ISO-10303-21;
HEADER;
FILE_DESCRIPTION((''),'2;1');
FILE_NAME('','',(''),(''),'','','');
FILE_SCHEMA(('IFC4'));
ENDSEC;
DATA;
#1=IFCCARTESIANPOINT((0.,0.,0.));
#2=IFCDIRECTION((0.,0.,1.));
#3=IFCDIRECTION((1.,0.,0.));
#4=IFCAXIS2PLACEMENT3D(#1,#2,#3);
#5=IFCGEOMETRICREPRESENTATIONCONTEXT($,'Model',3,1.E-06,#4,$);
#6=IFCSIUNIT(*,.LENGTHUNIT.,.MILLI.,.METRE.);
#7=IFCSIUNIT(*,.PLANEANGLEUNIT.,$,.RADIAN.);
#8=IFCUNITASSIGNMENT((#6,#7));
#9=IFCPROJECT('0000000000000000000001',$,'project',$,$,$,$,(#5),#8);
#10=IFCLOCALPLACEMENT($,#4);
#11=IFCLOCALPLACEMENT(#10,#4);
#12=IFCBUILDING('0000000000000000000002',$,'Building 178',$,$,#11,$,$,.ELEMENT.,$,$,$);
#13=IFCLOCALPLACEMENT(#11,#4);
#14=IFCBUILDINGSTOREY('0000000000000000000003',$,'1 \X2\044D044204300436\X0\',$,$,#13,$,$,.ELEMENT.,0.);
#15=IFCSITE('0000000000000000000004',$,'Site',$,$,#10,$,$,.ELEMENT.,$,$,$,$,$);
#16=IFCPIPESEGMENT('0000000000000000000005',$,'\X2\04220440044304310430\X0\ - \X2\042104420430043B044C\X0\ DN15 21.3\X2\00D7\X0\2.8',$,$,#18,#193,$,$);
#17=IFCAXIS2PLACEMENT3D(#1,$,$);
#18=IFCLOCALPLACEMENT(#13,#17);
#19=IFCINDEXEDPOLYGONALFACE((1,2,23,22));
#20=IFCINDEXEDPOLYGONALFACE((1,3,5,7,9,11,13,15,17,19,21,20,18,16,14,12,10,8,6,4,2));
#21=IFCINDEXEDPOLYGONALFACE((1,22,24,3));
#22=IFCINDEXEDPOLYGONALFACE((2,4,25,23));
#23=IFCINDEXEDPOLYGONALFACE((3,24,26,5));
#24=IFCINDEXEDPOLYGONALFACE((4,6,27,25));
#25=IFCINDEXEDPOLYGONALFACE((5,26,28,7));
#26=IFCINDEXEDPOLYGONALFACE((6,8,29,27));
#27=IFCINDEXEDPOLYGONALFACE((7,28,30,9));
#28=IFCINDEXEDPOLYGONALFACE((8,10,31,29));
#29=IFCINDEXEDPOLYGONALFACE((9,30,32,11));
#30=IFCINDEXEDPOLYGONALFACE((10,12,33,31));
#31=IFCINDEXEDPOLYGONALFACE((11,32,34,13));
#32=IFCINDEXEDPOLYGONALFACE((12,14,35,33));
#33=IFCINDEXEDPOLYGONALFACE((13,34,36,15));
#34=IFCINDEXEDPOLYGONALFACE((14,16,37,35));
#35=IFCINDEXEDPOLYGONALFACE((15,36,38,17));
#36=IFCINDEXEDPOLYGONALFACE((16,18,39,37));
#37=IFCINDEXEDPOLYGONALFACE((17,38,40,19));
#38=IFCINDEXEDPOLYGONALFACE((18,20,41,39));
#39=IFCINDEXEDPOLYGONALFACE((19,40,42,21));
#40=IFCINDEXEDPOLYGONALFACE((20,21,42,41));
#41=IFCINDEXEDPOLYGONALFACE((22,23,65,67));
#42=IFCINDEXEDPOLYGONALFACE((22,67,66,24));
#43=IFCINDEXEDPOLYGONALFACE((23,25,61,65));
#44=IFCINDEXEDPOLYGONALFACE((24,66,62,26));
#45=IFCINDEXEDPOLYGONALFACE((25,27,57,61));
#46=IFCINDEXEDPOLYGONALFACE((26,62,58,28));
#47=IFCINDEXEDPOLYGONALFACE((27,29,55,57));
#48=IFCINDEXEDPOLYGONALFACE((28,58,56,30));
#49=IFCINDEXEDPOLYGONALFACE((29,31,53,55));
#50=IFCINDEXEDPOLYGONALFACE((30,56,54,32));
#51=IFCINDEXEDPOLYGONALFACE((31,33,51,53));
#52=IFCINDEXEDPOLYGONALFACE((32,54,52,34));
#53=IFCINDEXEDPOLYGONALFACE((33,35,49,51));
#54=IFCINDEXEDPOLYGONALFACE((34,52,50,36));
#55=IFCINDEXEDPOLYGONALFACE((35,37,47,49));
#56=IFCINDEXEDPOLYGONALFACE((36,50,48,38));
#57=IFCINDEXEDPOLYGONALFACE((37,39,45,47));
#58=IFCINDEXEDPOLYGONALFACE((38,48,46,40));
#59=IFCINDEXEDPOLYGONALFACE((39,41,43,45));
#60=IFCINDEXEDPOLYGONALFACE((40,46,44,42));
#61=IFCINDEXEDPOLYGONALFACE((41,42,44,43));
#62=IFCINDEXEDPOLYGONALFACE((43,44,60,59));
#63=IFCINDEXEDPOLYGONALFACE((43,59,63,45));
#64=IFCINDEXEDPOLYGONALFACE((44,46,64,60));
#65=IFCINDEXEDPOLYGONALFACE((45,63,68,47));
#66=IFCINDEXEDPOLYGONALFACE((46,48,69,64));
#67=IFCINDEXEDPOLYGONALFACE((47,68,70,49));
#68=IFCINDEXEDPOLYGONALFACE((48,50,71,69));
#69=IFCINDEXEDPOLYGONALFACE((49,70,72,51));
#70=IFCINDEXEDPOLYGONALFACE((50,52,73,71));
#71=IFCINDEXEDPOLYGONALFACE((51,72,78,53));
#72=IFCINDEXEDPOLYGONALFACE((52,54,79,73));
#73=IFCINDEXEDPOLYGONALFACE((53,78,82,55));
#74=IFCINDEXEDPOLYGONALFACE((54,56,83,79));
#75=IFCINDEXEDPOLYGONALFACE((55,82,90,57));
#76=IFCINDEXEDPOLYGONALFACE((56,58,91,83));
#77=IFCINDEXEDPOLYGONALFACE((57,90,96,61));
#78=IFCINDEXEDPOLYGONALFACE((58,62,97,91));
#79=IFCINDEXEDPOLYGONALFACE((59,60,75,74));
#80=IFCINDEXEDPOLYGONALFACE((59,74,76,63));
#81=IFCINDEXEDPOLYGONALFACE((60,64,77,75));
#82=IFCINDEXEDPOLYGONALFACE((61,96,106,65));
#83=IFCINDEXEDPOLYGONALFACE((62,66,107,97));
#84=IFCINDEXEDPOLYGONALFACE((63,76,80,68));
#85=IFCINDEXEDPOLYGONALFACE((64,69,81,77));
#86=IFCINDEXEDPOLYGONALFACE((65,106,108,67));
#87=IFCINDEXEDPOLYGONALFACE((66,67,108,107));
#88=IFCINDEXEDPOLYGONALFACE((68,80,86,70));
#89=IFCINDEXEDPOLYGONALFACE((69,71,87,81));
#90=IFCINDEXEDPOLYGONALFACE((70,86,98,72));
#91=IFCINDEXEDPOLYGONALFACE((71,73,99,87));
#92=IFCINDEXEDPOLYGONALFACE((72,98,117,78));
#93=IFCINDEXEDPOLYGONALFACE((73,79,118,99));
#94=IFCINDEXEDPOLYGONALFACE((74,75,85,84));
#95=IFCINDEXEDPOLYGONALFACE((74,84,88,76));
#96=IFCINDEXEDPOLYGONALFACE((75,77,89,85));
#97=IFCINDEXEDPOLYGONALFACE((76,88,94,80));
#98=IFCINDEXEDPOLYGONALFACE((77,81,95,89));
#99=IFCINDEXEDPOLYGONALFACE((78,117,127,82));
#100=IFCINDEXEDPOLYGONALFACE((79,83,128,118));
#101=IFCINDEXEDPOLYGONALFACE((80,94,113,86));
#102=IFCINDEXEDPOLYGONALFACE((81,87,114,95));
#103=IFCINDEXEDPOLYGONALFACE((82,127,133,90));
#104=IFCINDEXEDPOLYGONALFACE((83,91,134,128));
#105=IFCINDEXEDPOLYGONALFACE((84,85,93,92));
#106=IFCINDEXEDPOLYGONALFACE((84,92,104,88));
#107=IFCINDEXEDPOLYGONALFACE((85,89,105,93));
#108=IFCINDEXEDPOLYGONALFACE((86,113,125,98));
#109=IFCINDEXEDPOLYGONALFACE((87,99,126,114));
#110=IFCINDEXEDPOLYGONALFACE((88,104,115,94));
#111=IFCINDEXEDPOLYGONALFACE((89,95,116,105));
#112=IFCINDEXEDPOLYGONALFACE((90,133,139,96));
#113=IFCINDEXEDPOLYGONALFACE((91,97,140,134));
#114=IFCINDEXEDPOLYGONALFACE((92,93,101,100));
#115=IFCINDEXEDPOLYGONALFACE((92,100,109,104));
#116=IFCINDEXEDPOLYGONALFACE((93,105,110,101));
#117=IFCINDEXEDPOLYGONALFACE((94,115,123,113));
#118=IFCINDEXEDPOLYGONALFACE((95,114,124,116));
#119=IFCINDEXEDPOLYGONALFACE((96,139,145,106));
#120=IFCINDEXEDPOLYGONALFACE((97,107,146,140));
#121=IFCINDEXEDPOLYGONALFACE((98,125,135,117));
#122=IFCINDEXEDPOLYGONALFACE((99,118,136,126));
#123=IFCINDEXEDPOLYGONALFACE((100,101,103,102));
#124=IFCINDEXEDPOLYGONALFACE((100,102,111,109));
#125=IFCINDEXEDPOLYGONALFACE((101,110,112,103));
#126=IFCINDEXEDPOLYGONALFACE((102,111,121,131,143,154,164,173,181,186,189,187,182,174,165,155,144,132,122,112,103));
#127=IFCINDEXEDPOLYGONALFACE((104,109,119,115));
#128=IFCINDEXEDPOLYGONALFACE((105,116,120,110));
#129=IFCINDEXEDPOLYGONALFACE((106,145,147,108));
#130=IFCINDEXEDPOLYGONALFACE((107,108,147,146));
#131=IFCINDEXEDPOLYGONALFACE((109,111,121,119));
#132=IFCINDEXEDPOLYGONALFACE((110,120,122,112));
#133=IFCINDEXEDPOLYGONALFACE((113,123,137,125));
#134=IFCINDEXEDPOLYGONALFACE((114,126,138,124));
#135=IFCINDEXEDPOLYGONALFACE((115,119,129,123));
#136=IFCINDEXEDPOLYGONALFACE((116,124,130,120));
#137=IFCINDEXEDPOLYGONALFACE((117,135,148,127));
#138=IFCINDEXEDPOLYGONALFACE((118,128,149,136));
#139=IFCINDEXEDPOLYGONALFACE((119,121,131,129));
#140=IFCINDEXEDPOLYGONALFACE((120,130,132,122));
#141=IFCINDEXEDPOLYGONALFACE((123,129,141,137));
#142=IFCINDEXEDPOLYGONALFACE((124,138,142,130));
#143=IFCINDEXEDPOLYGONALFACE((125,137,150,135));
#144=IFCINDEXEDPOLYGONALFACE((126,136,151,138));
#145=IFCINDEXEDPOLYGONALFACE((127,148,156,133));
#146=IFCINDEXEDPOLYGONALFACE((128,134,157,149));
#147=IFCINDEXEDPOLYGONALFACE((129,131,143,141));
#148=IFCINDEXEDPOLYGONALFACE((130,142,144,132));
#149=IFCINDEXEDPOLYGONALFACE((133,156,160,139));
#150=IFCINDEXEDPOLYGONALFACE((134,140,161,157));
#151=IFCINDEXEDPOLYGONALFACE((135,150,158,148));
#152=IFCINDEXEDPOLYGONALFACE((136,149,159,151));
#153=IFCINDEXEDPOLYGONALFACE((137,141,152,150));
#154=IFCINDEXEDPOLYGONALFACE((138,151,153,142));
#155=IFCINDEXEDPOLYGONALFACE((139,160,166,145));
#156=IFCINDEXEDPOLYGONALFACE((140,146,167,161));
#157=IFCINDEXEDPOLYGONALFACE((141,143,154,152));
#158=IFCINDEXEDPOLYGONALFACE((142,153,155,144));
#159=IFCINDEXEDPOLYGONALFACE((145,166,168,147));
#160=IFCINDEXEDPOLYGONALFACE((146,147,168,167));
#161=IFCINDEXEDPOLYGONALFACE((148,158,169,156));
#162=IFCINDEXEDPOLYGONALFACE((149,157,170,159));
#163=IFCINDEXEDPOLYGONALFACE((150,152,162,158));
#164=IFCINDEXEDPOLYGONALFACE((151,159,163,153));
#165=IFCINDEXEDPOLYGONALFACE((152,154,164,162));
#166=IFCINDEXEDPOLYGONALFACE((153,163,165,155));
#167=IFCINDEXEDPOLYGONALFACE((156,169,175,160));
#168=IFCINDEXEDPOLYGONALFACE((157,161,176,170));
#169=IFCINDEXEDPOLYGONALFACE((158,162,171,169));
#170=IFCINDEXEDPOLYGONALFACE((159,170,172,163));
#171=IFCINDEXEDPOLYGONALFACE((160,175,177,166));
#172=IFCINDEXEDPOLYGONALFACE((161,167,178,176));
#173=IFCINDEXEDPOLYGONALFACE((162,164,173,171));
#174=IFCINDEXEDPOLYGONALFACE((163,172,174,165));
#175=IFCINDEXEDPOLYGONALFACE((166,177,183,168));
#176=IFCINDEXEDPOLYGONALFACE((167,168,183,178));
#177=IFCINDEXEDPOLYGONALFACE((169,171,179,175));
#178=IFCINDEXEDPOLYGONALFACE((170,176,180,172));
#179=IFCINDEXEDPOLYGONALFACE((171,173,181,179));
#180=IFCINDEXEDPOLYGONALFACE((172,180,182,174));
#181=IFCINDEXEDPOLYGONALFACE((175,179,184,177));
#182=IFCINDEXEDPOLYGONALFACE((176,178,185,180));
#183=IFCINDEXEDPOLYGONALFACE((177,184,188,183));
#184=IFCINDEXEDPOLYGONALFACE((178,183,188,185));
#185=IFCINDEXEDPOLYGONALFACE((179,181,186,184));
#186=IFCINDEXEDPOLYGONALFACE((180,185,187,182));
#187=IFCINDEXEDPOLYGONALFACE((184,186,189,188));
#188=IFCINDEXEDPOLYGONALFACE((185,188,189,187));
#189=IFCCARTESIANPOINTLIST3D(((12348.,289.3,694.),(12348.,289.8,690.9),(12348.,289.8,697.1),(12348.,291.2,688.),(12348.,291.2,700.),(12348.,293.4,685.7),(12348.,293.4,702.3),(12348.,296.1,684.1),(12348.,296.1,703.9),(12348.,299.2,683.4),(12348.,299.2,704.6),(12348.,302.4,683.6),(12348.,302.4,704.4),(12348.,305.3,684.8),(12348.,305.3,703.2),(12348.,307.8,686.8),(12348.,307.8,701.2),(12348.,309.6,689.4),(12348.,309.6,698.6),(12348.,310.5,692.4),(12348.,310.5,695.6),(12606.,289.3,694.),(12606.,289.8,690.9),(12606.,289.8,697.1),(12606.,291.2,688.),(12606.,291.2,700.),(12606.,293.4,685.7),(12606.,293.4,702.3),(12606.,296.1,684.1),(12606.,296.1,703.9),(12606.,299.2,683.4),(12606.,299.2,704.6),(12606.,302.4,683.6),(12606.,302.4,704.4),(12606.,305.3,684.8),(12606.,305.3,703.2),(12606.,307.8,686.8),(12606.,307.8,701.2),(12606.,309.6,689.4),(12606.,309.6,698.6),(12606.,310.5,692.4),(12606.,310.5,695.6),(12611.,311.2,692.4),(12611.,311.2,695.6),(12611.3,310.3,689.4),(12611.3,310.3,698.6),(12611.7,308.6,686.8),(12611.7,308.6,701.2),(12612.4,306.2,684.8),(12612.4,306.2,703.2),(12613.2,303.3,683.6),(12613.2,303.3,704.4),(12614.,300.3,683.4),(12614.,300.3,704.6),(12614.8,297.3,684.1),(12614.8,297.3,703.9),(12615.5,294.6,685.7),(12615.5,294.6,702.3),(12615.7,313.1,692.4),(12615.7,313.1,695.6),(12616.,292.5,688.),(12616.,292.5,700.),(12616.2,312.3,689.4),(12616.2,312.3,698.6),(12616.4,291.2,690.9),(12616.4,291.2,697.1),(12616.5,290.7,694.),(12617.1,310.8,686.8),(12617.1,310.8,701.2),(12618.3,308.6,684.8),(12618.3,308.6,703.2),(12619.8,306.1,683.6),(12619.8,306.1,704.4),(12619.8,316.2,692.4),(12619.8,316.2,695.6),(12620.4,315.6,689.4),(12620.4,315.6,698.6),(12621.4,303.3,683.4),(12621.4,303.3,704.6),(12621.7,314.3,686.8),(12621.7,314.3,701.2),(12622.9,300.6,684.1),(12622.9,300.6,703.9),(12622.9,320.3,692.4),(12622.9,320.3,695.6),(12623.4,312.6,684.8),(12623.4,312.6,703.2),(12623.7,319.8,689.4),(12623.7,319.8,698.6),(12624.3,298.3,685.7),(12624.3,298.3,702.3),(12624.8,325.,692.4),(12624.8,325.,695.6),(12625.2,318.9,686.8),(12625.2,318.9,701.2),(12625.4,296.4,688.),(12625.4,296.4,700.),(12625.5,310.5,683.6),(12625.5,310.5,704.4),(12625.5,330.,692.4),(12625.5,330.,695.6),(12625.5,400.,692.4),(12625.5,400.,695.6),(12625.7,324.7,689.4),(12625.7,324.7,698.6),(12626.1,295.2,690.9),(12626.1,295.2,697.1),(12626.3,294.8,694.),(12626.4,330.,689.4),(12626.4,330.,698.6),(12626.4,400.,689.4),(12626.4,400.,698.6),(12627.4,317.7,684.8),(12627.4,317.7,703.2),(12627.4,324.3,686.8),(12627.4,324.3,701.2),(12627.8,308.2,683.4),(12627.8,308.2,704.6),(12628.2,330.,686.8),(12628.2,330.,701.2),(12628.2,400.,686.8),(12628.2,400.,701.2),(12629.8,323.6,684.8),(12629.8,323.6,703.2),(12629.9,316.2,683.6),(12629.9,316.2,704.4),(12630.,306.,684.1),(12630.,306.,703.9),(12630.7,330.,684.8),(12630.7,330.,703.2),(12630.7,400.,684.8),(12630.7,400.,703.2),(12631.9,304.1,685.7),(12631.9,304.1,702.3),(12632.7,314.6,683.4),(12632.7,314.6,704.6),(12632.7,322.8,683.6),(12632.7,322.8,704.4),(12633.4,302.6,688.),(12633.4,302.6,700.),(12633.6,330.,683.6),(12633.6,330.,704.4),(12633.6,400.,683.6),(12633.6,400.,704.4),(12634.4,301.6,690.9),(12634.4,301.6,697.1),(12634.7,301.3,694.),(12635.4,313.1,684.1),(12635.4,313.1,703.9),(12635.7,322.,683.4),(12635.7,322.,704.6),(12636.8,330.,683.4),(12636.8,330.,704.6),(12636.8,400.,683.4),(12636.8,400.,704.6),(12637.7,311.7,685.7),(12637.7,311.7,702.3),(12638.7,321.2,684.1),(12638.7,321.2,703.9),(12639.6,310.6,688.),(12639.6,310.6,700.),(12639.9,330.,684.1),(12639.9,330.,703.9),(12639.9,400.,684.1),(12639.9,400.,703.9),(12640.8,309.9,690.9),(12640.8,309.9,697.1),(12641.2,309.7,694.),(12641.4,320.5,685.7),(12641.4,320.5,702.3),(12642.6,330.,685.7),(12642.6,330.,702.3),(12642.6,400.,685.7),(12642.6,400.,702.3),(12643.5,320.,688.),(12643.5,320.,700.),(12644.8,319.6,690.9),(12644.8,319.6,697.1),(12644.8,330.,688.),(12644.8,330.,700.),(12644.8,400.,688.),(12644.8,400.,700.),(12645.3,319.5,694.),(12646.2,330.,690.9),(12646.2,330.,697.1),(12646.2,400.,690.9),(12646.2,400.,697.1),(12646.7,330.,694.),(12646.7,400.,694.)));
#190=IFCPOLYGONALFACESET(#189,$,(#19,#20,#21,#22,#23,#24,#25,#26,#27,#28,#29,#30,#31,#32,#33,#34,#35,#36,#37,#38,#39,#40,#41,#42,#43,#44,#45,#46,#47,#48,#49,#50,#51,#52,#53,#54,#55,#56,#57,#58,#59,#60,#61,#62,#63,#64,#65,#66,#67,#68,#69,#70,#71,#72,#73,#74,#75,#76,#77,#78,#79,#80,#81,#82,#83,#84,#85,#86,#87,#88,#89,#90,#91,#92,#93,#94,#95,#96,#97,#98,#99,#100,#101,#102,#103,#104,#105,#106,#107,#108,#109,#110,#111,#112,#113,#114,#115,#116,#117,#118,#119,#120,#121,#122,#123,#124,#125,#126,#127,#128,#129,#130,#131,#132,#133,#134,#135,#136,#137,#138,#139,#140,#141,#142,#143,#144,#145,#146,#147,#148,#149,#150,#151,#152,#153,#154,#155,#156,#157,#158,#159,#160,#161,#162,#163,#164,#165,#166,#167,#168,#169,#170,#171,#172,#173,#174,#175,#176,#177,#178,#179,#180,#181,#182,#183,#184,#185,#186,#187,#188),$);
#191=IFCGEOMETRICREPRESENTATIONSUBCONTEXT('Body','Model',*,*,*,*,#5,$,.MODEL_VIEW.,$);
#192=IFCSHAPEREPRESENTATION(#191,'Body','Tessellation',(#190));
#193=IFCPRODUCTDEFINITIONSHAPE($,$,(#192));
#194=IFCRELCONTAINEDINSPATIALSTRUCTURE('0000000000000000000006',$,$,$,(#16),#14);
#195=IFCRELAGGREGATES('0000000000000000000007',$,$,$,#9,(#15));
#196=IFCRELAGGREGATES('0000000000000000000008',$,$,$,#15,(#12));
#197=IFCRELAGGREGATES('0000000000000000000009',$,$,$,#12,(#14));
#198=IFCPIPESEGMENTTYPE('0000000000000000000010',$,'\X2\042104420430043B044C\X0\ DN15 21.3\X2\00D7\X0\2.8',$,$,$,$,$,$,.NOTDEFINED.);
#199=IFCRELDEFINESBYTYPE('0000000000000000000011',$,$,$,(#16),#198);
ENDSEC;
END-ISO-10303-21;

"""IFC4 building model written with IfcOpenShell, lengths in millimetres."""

from ifc_helpers import new_model, entity, si_unit, frame, origin_with_axes, place, context, subcontext, project, spatial, source, transform, mapped, type_object, element, save


model = new_model("IFC4")

# Units and contexts
model_context = context("Model", 3, precision=1e-06, world=origin_with_axes())
body_context = subcontext(model_context, "Body", "Model", "MODEL_VIEW")
ifc_project = project(units=[si_unit("LENGTHUNIT", "METRE", prefix="MILLI"), si_unit("PLANEANGLEUNIT", "RADIAN")], contexts=[model_context])

# Site, building, storey
site_placement = place(None, origin_with_axes())
site = spatial("IfcSite", under=ifc_project, at=site_placement, Name="Site", CompositionType="ELEMENT")
building_placement = place(site_placement, origin_with_axes())
building = spatial("IfcBuilding", under=site, at=building_placement, Name="Building 178", CompositionType="ELEMENT")
storey_placement = place(building_placement, origin_with_axes())
storey = spatial("IfcBuildingStorey", under=building, at=storey_placement, Name="1 этаж", CompositionType="ELEMENT", Elevation=0.0)

# Pipe segment
pipe_segment_type = type_object("IfcPipeSegmentType", Name="Сталь DN15 21.3×2.8", PredefinedType="NOTDEFINED")
shared_shape_1 = source(origin_with_axes(), body_context, "Body", "AdvancedSweptSolid", [
    entity("IfcSweptDiskSolid", entity("IfcIndexedPolyCurve", entity("IfcCartesianPointList3D", [[0.0, 0.0, 0.0], [0.0, 0.0, -70.0], [8.8, 0.0, -91.2], [30.0, 0.0, -100.0], [288.0, 0.0, -100.0]]), [entity("IfcLineIndex", [1, 2]), entity("IfcArcIndex", [2, 3, 4]), entity("IfcLineIndex", [4, 5])]), 10.7),
])
for number, where, z_axis, x_axis, name in (
    (1, (12636.0, 400.0, 694.0), (0.0, 1.0, 0.0), (-1.0, 0.0, 0.0), "Труба - Сталь DN15 21.3×2.8"),
):
    element("IfcPipeSegment", number, at=place(storey_placement, frame(where, z_axis=z_axis, x_axis=x_axis)), inside=storey, type_object=pipe_segment_type, Name=name, context=body_context, shape_type="MappedRepresentation", body=[
        mapped(shared_shape_1, transform((0.0, 0.0, 0.0), x_axis=(1.0, 0.0, 0.0), y_axis=(0.0, 1.0, 0.0), z_axis=(0.0, 0.0, 1.0), scale=1.0)),
    ])

save(model, "model.ifc")
